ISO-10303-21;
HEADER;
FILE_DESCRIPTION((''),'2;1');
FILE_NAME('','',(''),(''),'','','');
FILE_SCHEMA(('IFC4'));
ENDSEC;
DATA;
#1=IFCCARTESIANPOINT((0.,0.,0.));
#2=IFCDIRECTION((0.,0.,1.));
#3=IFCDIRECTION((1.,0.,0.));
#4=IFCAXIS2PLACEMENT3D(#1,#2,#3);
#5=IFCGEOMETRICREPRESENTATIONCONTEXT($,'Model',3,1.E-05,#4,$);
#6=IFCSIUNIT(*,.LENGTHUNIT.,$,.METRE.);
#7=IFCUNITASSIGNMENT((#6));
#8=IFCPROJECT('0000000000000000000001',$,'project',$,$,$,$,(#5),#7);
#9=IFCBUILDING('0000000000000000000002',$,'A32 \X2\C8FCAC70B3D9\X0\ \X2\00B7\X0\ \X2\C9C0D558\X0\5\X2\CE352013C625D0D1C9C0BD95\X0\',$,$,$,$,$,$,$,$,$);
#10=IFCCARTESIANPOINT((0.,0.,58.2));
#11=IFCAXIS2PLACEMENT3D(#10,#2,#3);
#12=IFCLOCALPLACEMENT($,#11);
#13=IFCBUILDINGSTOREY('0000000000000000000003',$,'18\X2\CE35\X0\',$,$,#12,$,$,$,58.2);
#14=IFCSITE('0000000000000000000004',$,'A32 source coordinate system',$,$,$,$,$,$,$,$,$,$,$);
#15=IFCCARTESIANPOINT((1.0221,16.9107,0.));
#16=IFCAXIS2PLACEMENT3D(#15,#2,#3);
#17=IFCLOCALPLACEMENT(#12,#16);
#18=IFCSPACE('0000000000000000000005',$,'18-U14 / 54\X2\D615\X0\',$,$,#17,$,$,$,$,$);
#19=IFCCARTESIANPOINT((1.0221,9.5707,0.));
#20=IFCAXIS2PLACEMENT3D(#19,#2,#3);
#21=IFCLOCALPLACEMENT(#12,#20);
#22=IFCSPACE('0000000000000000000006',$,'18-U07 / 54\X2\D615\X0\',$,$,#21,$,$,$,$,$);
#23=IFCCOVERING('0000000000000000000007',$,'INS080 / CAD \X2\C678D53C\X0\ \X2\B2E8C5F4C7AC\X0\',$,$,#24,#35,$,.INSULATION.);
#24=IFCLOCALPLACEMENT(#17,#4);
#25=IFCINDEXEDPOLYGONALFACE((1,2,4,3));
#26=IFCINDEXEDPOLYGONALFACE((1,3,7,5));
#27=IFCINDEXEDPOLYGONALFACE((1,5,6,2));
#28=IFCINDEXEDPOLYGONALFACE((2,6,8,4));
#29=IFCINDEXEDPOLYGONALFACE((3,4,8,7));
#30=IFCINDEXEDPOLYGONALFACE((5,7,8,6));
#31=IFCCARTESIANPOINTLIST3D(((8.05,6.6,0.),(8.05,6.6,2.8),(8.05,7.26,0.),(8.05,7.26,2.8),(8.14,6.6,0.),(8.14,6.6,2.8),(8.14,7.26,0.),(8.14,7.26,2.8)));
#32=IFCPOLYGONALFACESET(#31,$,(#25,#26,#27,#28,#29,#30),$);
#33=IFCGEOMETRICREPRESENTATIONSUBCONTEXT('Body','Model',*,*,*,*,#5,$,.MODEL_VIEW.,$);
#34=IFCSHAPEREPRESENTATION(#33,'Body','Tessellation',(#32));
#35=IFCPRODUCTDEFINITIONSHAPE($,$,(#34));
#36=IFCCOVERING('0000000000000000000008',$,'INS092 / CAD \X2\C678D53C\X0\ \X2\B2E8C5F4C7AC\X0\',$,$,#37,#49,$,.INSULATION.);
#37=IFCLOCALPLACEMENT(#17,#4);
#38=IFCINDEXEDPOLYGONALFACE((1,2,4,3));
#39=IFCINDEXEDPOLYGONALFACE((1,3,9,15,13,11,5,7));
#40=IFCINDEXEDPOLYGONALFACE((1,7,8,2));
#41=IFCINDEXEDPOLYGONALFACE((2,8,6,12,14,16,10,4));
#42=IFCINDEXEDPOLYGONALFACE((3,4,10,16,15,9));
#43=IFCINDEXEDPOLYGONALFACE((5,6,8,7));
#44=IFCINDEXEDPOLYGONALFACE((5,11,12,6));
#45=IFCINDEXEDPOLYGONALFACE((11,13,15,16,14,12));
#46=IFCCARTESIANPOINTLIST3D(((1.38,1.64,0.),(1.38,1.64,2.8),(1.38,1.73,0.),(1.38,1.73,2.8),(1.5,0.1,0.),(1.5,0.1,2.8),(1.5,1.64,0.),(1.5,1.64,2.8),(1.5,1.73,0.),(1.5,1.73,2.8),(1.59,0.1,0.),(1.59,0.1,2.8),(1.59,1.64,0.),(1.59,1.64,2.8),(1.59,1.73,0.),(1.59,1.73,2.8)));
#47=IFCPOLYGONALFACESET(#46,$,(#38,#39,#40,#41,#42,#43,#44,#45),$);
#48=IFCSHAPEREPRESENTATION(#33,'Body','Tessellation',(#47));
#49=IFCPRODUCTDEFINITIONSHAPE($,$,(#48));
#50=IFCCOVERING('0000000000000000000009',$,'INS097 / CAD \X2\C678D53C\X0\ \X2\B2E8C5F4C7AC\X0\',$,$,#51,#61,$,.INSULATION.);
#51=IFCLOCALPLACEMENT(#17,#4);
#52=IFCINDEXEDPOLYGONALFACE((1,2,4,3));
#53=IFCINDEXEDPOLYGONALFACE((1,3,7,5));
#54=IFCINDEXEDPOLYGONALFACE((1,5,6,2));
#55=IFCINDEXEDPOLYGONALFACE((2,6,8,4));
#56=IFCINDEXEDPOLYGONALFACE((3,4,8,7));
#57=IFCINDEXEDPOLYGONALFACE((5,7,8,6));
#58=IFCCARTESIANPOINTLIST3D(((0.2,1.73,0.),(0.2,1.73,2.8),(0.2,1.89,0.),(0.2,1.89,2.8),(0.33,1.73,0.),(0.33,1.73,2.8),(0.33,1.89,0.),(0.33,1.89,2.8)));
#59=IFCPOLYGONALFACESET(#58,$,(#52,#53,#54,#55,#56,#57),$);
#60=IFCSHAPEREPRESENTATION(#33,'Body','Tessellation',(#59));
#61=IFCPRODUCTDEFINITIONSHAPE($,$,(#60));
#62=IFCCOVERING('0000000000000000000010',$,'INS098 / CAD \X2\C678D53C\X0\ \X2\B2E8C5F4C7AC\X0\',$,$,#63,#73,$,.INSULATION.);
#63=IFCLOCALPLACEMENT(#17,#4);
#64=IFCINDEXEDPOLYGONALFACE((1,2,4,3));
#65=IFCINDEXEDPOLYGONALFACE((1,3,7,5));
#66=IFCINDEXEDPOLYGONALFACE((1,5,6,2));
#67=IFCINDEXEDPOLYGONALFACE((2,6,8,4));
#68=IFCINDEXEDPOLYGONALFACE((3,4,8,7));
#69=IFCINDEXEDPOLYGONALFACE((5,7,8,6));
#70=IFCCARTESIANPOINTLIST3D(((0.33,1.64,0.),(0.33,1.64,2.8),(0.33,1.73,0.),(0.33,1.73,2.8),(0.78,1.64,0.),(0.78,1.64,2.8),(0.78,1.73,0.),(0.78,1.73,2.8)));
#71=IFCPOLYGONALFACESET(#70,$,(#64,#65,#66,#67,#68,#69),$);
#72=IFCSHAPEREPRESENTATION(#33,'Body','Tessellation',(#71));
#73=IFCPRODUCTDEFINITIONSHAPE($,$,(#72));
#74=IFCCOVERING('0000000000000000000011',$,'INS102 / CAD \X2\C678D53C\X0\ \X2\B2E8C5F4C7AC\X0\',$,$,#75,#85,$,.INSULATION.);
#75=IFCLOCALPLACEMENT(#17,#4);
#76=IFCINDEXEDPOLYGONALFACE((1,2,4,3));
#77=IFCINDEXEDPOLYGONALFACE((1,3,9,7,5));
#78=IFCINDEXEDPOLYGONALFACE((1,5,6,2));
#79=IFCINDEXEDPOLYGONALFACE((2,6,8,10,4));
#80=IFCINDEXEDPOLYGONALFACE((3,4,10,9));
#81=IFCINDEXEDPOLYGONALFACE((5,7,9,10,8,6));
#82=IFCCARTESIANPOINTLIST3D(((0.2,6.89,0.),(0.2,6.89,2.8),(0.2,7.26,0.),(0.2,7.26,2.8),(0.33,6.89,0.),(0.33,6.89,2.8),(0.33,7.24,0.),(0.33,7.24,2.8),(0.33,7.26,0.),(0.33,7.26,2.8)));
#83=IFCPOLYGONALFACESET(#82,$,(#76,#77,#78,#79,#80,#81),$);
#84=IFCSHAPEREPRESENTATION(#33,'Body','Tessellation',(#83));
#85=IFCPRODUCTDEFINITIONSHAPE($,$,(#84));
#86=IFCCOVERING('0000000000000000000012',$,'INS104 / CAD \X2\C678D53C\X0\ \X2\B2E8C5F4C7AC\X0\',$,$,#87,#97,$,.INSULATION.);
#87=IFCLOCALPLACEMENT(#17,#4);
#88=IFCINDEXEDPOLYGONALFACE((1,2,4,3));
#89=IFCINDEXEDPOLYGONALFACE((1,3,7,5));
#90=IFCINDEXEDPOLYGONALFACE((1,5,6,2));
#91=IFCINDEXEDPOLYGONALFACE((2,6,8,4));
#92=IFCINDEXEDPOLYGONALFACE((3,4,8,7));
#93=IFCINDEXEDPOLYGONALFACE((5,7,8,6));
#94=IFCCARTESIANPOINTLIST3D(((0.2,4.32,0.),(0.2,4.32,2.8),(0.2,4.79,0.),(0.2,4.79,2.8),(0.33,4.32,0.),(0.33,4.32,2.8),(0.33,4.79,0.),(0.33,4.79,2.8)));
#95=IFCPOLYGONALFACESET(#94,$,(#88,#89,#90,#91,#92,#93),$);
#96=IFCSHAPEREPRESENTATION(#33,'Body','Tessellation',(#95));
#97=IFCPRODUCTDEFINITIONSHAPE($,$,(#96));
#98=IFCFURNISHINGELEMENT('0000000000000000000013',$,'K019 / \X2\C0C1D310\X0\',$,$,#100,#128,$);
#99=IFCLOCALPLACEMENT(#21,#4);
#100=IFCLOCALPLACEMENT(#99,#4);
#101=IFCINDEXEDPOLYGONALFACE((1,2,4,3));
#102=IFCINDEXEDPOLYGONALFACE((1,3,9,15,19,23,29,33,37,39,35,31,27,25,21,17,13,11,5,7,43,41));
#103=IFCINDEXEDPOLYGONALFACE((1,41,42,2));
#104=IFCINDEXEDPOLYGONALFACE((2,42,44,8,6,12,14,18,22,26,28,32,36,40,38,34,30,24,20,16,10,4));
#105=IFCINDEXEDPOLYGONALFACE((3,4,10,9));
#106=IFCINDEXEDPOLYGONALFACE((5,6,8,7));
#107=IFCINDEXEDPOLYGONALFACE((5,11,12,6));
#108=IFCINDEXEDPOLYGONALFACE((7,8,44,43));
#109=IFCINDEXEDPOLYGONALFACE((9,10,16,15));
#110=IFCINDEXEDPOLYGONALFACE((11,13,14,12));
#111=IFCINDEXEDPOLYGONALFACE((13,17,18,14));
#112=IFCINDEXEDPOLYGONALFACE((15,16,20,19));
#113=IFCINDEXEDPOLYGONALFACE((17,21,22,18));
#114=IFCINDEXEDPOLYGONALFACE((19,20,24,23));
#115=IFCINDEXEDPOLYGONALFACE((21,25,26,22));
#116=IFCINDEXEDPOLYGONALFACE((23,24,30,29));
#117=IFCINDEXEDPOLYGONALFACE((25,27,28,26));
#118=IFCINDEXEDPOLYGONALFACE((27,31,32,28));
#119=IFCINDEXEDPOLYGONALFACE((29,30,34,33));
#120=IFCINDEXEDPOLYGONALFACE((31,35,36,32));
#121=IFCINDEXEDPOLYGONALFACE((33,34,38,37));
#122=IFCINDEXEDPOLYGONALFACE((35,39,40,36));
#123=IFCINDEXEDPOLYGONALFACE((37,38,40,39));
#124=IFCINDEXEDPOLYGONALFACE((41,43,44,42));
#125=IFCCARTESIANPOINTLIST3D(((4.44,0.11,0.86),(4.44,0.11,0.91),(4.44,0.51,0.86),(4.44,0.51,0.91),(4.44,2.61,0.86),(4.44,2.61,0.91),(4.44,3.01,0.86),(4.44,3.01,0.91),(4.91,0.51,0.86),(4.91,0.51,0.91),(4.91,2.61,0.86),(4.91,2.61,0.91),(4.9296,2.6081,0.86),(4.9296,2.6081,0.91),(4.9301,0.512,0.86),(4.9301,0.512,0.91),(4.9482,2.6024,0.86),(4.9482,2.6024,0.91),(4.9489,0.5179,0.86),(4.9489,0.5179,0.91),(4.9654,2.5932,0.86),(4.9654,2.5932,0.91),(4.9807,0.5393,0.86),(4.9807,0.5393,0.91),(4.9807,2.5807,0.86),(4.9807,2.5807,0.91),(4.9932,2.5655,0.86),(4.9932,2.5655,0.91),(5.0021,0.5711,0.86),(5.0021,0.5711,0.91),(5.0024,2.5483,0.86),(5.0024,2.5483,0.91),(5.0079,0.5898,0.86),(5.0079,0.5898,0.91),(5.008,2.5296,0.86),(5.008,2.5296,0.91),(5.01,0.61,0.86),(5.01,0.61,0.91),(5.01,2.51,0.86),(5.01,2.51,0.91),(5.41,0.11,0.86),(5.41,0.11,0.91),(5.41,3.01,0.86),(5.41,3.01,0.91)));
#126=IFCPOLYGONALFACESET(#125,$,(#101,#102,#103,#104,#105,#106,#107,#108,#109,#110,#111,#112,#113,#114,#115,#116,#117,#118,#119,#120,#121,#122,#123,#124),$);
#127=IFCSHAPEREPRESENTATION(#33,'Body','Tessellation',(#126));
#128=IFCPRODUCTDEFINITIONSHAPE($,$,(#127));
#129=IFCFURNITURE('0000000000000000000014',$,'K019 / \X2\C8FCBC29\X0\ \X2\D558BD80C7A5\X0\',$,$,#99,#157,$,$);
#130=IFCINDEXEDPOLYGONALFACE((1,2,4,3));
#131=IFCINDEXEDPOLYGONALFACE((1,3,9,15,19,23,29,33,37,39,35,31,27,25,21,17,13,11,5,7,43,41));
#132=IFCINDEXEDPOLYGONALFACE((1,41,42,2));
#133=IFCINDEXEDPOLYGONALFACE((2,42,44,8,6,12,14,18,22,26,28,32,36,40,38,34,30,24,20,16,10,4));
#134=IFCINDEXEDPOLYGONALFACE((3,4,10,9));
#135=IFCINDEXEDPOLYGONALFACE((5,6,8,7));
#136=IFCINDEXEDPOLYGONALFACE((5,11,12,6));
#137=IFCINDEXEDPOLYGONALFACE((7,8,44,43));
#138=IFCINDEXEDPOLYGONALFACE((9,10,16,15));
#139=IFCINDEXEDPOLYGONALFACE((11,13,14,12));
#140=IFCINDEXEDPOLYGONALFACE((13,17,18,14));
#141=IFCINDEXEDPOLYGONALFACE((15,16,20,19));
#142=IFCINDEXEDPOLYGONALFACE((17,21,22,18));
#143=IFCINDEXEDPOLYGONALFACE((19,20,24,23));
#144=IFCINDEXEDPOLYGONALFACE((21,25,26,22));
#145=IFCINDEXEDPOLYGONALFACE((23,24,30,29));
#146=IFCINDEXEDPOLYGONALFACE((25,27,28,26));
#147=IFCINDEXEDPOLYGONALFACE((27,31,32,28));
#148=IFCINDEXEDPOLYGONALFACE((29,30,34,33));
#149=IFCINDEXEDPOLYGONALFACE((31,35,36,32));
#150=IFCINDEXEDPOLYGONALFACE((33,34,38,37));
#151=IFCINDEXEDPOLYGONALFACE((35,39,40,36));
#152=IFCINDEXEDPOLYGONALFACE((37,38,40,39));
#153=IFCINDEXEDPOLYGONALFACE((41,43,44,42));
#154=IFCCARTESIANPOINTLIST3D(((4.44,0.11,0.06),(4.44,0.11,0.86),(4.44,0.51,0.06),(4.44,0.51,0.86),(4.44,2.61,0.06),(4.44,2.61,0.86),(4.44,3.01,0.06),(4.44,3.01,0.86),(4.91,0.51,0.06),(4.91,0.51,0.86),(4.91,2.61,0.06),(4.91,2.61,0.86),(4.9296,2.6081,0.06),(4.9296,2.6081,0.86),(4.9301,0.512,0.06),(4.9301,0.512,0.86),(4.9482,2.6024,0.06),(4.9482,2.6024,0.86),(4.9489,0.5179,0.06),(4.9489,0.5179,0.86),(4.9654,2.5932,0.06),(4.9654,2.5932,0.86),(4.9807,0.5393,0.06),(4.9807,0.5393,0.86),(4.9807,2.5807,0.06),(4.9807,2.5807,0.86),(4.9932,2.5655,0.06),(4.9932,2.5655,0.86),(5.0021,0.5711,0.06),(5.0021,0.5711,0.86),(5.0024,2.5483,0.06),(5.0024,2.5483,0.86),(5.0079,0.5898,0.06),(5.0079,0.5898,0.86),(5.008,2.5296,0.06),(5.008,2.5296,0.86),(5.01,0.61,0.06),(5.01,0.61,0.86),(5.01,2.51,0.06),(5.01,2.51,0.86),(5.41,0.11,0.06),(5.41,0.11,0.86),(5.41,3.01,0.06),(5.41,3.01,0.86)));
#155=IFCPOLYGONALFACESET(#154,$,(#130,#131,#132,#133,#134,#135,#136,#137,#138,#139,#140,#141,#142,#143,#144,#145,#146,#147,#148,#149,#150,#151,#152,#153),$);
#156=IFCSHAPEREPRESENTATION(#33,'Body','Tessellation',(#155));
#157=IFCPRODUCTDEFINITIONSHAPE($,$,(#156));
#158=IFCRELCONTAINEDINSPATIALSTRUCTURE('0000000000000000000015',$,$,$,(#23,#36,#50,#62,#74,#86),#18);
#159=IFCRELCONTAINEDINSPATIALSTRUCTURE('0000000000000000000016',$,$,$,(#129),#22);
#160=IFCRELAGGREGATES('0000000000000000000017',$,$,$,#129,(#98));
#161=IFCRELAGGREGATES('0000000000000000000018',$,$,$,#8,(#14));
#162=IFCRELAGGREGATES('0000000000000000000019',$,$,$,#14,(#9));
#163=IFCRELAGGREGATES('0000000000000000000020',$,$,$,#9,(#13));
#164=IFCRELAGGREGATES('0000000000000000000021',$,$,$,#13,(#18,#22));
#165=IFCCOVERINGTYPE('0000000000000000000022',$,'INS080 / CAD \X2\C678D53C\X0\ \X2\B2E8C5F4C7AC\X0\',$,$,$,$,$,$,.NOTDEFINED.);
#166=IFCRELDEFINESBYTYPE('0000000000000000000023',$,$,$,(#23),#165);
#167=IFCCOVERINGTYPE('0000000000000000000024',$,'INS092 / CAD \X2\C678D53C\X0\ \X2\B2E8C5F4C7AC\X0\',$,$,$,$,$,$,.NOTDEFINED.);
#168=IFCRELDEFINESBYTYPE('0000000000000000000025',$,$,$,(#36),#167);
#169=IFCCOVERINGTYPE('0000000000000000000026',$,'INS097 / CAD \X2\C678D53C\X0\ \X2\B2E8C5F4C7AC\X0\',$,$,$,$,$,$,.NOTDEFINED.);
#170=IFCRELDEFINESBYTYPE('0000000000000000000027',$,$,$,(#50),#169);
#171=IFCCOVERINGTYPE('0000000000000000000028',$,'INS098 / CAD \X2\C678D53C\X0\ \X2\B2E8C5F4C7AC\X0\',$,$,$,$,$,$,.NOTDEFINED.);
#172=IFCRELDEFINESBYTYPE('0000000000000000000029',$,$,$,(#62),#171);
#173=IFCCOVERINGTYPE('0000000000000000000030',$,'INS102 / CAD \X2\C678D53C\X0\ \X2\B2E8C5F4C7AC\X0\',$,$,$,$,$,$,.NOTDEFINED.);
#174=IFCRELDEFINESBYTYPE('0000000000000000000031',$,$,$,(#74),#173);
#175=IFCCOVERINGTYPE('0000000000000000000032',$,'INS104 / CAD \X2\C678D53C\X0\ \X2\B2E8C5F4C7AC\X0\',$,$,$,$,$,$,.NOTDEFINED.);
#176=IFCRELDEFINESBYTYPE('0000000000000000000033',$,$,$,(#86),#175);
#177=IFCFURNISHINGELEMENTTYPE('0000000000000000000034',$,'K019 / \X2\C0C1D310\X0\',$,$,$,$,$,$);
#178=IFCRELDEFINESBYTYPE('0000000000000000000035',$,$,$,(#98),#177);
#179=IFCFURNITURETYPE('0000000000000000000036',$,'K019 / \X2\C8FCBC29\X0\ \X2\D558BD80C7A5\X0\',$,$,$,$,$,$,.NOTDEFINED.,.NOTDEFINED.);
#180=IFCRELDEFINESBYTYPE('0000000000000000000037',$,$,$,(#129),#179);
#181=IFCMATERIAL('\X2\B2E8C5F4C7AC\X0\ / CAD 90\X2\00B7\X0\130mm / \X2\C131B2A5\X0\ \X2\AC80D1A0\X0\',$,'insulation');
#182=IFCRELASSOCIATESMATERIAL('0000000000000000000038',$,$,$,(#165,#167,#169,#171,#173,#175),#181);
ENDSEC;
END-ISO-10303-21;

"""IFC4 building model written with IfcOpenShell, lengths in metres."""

from ifc_helpers import new_model, si_unit, frame, origin, origin_with_axes, place, context, subcontext, project, spatial, polyline, outline, extrude, source, transform, mapped, material, type_object, type_shapes, element, aggregate, save


model = new_model("IFC4")

# Units and contexts
model_context = context("Model", 3, precision=1e-05, world=origin_with_axes())
body_context = subcontext(model_context, "Body", "Model", "MODEL_VIEW")
ifc_project = project(units=[si_unit("LENGTHUNIT", "METRE")], contexts=[model_context])

# Site, building, storey, space
storey_placement = place(None, frame((0.0, 0.0, 58.2), z_axis=(0.0, 0.0, 1.0), x_axis=(1.0, 0.0, 0.0)))
space_1_placement = place(storey_placement, frame((1.0221, 16.9107, 0.0), z_axis=(0.0, 0.0, 1.0), x_axis=(1.0, 0.0, 0.0)))
site = spatial("IfcSite", under=ifc_project, Name="A32 source coordinate system")
building = spatial("IfcBuilding", under=site, Name="A32 주거동 · 지하5층–옥탑지붕")
storey = spatial("IfcBuildingStorey", under=building, at=storey_placement, Name="18층", Elevation=58.2)
space_1 = spatial("IfcSpace", under=storey, at=space_1_placement, Name="18-U14 / 54형")

# Coverings
ifc_material = material(Name="단열재 / CAD 90·130mm / 성능 검토", Category="insulation")
covering_type_1 = type_object("IfcCoveringType", Name="INS080 / CAD 외피 단열재", PredefinedType="NOTDEFINED", material=ifc_material)
shared_shape_1 = source(origin(), body_context, "Body", "SweptSolid", [
    extrude(outline(polyline([(8.14, 7.26), (8.14, 6.6), (8.05, 6.6), (8.05, 7.26), (8.14, 7.26)])), origin(), (0.0, 0.0, 1.0), 2.8),
])
type_shapes(covering_type_1, [shared_shape_1])
covering_1_placement = place(space_1_placement, origin_with_axes())
element("IfcCovering", 1, at=covering_1_placement, inside=space_1, type_object=covering_type_1, Name="INS080 / CAD 외피 단열재", PredefinedType="INSULATION", context=body_context, shape_type="MappedRepresentation", body=[
    mapped(shared_shape_1, transform((0.0, 0.0, 0.0), scale=1.0)),
])
covering_type_2 = type_object("IfcCoveringType", Name="INS092 / CAD 외피 단열재", PredefinedType="NOTDEFINED", material=ifc_material)
shared_shape_2 = source(origin(), body_context, "Body", "SweptSolid", [
    extrude(outline(polyline([(1.59, 1.73), (1.59, 1.64), (1.59, 0.1), (1.5, 0.1), (1.5, 1.64), (1.38, 1.64), (1.38, 1.73), (1.5, 1.73), (1.59, 1.73)])), origin(), (0.0, 0.0, 1.0), 2.8),
])
type_shapes(covering_type_2, [shared_shape_2])
covering_2_placement = place(space_1_placement, origin_with_axes())
element("IfcCovering", 2, at=covering_2_placement, inside=space_1, type_object=covering_type_2, Name="INS092 / CAD 외피 단열재", PredefinedType="INSULATION", context=body_context, shape_type="MappedRepresentation", body=[
    mapped(shared_shape_2, transform((0.0, 0.0, 0.0), scale=1.0)),
])
covering_type_3 = type_object("IfcCoveringType", Name="INS097 / CAD 외피 단열재", PredefinedType="NOTDEFINED", material=ifc_material)
shared_shape_3 = source(origin(), body_context, "Body", "SweptSolid", [
    extrude(outline(polyline([(0.33, 1.89), (0.33, 1.73), (0.2, 1.73), (0.2, 1.89), (0.33, 1.89)])), origin(), (0.0, 0.0, 1.0), 2.8),
])
type_shapes(covering_type_3, [shared_shape_3])
covering_3_placement = place(space_1_placement, origin_with_axes())
element("IfcCovering", 3, at=covering_3_placement, inside=space_1, type_object=covering_type_3, Name="INS097 / CAD 외피 단열재", PredefinedType="INSULATION", context=body_context, shape_type="MappedRepresentation", body=[
    mapped(shared_shape_3, transform((0.0, 0.0, 0.0), scale=1.0)),
])
covering_type_4 = type_object("IfcCoveringType", Name="INS098 / CAD 외피 단열재", PredefinedType="NOTDEFINED", material=ifc_material)
shared_shape_4 = source(origin(), body_context, "Body", "SweptSolid", [
    extrude(outline(polyline([(0.78, 1.73), (0.78, 1.64), (0.33, 1.64), (0.33, 1.73), (0.78, 1.73)])), origin(), (0.0, 0.0, 1.0), 2.8),
])
type_shapes(covering_type_4, [shared_shape_4])
covering_4_placement = place(space_1_placement, origin_with_axes())
element("IfcCovering", 4, at=covering_4_placement, inside=space_1, type_object=covering_type_4, Name="INS098 / CAD 외피 단열재", PredefinedType="INSULATION", context=body_context, shape_type="MappedRepresentation", body=[
    mapped(shared_shape_4, transform((0.0, 0.0, 0.0), scale=1.0)),
])
covering_type_5 = type_object("IfcCoveringType", Name="INS102 / CAD 외피 단열재", PredefinedType="NOTDEFINED", material=ifc_material)
shared_shape_5 = source(origin(), body_context, "Body", "SweptSolid", [
    extrude(outline(polyline([(0.33, 7.26), (0.33, 7.24), (0.33, 6.89), (0.2, 6.89), (0.2, 7.26), (0.33, 7.26)])), origin(), (0.0, 0.0, 1.0), 2.8),
])
type_shapes(covering_type_5, [shared_shape_5])
covering_5_placement = place(space_1_placement, origin_with_axes())
element("IfcCovering", 5, at=covering_5_placement, inside=space_1, type_object=covering_type_5, Name="INS102 / CAD 외피 단열재", PredefinedType="INSULATION", context=body_context, shape_type="MappedRepresentation", body=[
    mapped(shared_shape_5, transform((0.0, 0.0, 0.0), scale=1.0)),
])
covering_type_6 = type_object("IfcCoveringType", Name="INS104 / CAD 외피 단열재", PredefinedType="NOTDEFINED", material=ifc_material)
shared_shape_6 = source(origin(), body_context, "Body", "SweptSolid", [
    extrude(outline(polyline([(0.33, 4.32), (0.2, 4.32), (0.2, 4.79), (0.33, 4.79), (0.33, 4.32)])), origin(), (0.0, 0.0, 1.0), 2.8),
])
type_shapes(covering_type_6, [shared_shape_6])
covering_6_placement = place(space_1_placement, origin_with_axes())
element("IfcCovering", 6, at=covering_6_placement, inside=space_1, type_object=covering_type_6, Name="INS104 / CAD 외피 단열재", PredefinedType="INSULATION", context=body_context, shape_type="MappedRepresentation", body=[
    mapped(shared_shape_6, transform((0.0, 0.0, 0.0), scale=1.0)),
])

# Furnishing element
furnishing_element_type = type_object("IfcFurnishingElementType", Name="K019 / 상판")
shared_shape_7 = source(origin(), body_context, "Body", "SweptSolid", [
    extrude(outline(polyline([(4.91, 0.51), (4.9301, 0.512), (4.9489, 0.5179), (4.9807, 0.5393), (5.0021, 0.5711), (5.0079, 0.5898), (5.01, 0.61), (5.01, 2.51), (5.008, 2.5296), (5.0024, 2.5483), (4.9932, 2.5655), (4.9807, 2.5807), (4.9654, 2.5932), (4.9482, 2.6024), (4.9296, 2.6081), (4.91, 2.61), (4.44, 2.61), (4.44, 3.01), (5.41, 3.01), (5.41, 0.11), (4.44, 0.11), (4.44, 0.51), (4.91, 0.51)])), frame((0.0, 0.0, 0.86)), (0.0, 0.0, 1.0), 0.05),
])
type_shapes(furnishing_element_type, [shared_shape_7])
space_2_placement = place(storey_placement, frame((1.0221, 9.5707, 0.0), z_axis=(0.0, 0.0, 1.0), x_axis=(1.0, 0.0, 0.0)))
furniture_placement = place(space_2_placement, origin_with_axes())
furnishing_placement = place(furniture_placement, origin_with_axes())
furnishing = element("IfcFurnishingElement", 7, at=furnishing_placement, type_object=furnishing_element_type, Name="K019 / 상판", context=body_context, shape_type="MappedRepresentation", body=[
    mapped(shared_shape_7, transform((0.0, 0.0, 0.0), scale=1.0)),
])

# Shared definitions
space_2 = spatial("IfcSpace", under=storey, at=space_2_placement, Name="18-U07 / 54형")

# Furniture
furniture_type = type_object("IfcFurnitureType", Name="K019 / 주방 하부장", AssemblyPlace="NOTDEFINED", PredefinedType="NOTDEFINED")
shared_shape_8 = source(origin(), body_context, "Body", "SweptSolid", [
    extrude(outline(polyline([(4.44, 0.51), (4.91, 0.51), (4.9301, 0.512), (4.9489, 0.5179), (4.9807, 0.5393), (5.0021, 0.5711), (5.0079, 0.5898), (5.01, 0.61), (5.01, 2.51), (5.008, 2.5296), (5.0024, 2.5483), (4.9932, 2.5655), (4.9807, 2.5807), (4.9654, 2.5932), (4.9482, 2.6024), (4.9296, 2.6081), (4.91, 2.61), (4.44, 2.61), (4.44, 3.01), (5.41, 3.01), (5.41, 0.11), (4.44, 0.11), (4.44, 0.51)])), frame((0.0, 0.0, 0.06)), (0.0, 0.0, 1.0), 0.8),
])
type_shapes(furniture_type, [shared_shape_8])
furniture = element("IfcFurniture", 8, at=furniture_placement, inside=space_2, type_object=furniture_type, Name="K019 / 주방 하부장", context=body_context, shape_type="MappedRepresentation", body=[
    mapped(shared_shape_8, transform((0.0, 0.0, 0.0), scale=1.0)),
])
aggregate(furniture, [furnishing])

save(model, "model.ifc")
